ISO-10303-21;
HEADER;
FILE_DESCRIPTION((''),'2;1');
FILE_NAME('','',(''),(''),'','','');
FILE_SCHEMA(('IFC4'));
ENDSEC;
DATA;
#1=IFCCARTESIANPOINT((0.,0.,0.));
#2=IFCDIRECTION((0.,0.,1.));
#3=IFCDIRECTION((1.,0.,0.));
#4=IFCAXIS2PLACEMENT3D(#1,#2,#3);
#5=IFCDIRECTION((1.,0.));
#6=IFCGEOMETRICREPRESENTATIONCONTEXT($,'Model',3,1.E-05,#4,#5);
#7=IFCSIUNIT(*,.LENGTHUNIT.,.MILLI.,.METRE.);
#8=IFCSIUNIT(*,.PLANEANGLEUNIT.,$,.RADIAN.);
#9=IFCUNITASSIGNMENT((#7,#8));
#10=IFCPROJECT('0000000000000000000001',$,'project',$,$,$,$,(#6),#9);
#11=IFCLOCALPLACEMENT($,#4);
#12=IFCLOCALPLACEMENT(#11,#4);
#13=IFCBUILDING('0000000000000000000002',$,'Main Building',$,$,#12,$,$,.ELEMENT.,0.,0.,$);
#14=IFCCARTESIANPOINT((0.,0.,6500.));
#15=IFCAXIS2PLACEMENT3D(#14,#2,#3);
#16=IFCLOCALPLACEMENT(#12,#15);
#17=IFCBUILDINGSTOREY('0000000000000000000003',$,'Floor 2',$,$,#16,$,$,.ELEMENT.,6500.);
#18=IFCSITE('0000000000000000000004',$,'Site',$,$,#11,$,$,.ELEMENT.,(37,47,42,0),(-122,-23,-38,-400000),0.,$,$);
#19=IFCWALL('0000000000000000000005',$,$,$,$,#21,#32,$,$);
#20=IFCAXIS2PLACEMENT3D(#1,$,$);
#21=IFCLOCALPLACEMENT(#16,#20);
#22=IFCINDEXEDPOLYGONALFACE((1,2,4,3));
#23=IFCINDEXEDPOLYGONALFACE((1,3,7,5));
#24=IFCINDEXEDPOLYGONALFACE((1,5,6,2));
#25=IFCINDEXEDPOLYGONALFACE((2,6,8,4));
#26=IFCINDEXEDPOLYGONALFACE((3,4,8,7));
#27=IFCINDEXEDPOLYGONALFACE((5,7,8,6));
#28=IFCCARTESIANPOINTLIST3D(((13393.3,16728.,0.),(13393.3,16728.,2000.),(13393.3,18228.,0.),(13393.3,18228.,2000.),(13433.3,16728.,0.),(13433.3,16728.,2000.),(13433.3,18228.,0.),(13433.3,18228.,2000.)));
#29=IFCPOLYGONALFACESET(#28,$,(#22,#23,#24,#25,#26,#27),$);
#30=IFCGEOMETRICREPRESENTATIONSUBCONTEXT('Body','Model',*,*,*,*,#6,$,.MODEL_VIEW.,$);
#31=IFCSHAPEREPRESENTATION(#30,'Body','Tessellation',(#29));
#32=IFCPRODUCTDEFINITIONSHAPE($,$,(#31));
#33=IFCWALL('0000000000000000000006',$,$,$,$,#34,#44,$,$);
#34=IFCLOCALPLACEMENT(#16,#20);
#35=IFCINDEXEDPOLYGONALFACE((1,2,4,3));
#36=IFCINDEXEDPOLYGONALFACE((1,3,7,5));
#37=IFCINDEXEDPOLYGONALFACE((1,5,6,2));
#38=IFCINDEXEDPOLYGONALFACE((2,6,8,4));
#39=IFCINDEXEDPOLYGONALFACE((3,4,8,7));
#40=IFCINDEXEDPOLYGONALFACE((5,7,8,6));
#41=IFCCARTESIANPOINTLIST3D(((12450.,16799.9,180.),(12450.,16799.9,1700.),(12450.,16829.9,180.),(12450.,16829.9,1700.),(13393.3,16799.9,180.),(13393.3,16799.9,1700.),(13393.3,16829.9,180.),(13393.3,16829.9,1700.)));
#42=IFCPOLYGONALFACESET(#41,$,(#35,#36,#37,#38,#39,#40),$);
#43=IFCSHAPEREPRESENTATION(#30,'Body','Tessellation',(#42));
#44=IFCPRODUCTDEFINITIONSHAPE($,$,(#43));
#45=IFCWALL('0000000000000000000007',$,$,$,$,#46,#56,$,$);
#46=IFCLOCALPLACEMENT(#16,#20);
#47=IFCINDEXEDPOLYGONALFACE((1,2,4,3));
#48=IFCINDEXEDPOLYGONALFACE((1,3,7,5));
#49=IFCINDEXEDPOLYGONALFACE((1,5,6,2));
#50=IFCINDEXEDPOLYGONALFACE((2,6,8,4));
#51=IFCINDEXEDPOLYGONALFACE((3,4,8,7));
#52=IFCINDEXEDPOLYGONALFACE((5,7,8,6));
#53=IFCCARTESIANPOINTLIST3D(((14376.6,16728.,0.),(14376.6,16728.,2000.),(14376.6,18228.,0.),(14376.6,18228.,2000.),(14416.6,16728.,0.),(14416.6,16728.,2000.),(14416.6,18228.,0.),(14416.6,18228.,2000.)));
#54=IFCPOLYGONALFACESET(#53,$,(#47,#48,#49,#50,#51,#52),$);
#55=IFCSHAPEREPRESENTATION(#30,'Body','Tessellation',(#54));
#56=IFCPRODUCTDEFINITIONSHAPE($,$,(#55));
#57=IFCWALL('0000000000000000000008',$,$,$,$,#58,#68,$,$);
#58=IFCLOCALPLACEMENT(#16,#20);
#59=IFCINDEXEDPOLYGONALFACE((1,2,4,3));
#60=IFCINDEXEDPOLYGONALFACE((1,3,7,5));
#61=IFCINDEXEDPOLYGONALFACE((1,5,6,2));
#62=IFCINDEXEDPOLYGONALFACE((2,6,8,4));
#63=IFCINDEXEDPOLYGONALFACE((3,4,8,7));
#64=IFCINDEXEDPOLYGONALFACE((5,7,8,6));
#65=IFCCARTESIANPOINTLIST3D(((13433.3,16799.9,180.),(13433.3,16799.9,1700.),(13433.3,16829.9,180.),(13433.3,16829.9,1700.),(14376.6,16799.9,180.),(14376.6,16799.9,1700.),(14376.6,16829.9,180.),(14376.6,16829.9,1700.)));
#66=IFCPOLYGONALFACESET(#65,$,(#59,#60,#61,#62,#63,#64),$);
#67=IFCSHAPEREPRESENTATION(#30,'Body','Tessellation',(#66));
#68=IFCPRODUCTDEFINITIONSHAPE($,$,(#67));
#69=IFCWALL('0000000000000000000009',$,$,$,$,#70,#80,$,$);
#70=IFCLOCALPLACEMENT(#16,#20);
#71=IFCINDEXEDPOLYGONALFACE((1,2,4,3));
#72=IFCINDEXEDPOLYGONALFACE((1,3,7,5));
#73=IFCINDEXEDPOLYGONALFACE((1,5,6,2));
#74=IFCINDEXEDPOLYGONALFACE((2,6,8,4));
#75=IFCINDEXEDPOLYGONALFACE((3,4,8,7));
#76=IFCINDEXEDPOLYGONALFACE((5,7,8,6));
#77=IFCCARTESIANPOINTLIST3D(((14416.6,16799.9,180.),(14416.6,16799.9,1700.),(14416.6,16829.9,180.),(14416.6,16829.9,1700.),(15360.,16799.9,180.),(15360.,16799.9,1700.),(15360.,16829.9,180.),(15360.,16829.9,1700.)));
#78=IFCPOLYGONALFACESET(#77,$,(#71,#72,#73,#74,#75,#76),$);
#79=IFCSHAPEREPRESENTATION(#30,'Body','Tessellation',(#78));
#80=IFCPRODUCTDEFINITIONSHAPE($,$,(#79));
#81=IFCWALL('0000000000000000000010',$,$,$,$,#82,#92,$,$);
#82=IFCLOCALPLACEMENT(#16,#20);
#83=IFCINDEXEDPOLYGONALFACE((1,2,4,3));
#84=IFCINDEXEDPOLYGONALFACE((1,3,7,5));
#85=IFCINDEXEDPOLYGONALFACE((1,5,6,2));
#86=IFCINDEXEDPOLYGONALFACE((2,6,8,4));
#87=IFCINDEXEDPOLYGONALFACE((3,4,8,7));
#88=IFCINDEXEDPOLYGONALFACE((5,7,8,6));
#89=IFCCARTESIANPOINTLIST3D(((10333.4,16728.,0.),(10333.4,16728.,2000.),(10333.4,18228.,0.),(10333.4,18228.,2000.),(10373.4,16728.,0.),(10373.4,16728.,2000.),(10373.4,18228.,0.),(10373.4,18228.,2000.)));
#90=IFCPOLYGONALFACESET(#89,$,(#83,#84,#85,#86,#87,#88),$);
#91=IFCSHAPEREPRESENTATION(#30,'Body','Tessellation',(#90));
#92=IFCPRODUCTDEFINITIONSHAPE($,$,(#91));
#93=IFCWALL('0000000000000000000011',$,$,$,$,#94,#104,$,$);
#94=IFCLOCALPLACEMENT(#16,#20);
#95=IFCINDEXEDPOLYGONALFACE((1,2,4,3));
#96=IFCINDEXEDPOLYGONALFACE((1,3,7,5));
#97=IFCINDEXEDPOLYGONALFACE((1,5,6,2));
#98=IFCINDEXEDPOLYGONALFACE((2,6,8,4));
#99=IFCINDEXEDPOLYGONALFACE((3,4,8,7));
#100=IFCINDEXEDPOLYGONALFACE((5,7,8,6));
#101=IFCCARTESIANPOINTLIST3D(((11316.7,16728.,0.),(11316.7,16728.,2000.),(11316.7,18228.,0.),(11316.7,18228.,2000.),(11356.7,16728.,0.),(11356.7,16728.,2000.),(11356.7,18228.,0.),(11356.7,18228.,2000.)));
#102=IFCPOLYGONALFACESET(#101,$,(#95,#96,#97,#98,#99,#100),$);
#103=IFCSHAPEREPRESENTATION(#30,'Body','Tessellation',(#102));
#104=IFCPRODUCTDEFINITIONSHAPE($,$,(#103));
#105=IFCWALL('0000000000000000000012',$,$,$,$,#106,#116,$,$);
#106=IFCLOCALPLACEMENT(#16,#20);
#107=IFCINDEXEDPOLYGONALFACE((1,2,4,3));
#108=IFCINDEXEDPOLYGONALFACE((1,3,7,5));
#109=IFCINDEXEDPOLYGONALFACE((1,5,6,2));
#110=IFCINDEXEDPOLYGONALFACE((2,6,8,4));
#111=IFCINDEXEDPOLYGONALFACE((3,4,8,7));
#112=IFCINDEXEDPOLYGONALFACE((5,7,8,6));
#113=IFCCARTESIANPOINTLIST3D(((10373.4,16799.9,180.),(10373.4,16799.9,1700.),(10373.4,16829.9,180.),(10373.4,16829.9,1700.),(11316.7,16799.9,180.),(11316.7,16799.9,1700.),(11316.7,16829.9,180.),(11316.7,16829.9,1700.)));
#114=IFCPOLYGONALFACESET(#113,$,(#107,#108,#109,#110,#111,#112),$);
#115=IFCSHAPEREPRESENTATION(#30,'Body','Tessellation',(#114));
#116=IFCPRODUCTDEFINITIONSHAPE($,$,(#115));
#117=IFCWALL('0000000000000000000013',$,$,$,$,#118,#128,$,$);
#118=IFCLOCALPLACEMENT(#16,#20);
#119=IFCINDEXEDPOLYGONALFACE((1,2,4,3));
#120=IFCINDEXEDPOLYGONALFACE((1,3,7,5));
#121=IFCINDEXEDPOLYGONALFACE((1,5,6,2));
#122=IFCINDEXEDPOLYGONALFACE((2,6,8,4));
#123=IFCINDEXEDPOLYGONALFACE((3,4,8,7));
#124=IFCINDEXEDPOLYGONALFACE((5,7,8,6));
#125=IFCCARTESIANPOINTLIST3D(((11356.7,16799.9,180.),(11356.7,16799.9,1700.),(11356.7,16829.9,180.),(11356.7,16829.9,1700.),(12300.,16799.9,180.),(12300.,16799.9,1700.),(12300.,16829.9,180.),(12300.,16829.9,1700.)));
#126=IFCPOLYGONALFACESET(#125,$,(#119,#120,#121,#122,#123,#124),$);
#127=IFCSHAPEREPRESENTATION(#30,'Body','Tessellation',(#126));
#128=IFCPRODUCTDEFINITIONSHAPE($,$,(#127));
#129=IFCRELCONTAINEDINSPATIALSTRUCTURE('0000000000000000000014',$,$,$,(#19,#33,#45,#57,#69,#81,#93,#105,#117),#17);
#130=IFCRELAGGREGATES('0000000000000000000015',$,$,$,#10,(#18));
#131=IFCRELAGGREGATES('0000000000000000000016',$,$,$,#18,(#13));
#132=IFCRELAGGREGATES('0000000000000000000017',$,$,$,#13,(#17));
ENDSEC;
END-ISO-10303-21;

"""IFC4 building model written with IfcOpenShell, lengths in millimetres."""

from ifc_helpers import new_model, si_unit, direction, frame, frame_2d, origin_with_axes, origin_2d_with_axis, place, context, subcontext, project, spatial, rectangle, extrude, element, save


model = new_model("IFC4")

# Units and contexts
model_context = context("Model", 3, precision=1e-05, world=origin_with_axes(), true_north=direction((1.0, 0.0)))
body_context = subcontext(model_context, "Body", "Model", "MODEL_VIEW")
ifc_project = project(units=[si_unit("LENGTHUNIT", "METRE", prefix="MILLI"), si_unit("PLANEANGLEUNIT", "RADIAN")], contexts=[model_context])

# Site, building, storey
site_placement = place(None, origin_with_axes())
site = spatial("IfcSite", under=ifc_project, at=site_placement, Name="Site", CompositionType="ELEMENT", RefLatitude=(37, 47, 42, 0), RefLongitude=(-122, -23, -38, -400000), RefElevation=0.0)
building_placement = place(site_placement, origin_with_axes())
building = spatial("IfcBuilding", under=site, at=building_placement, Name="Main Building", CompositionType="ELEMENT", ElevationOfRefHeight=0.0, ElevationOfTerrain=0.0)
storey_placement = place(building_placement, frame((0.0, 0.0, 6500.0), z_axis=(0.0, 0.0, 1.0), x_axis=(1.0, 0.0, 0.0)))
storey = spatial("IfcBuildingStorey", under=building, at=storey_placement, Name="Floor 2", CompositionType="ELEMENT", Elevation=6500.0)

# Walls
wall_1_placement = place(storey_placement, origin_with_axes())
element("IfcWall", 1, at=wall_1_placement, inside=storey, context=body_context, shape_type="SweptSolid", body=[
    extrude(rectangle(XDim=1500.0, YDim=40.0, at=frame_2d((0.0, 0.0), x_axis=(0.0, 1.0))), frame((13413.3, 17478.0, 0.0), z_axis=(0.0, 0.0, 1.0), x_axis=(1.0, 0.0, 0.0)), (0.0, 0.0, 1.0), 2000.0),
])
wall_2_placement = place(storey_placement, origin_with_axes())
element("IfcWall", 2, at=wall_2_placement, inside=storey, context=body_context, shape_type="SweptSolid", body=[
    extrude(rectangle(XDim=943.3, YDim=30.0, at=origin_2d_with_axis()), frame((12921.7, 16814.9, 180.0), z_axis=(0.0, 0.0, 1.0), x_axis=(1.0, 0.0, 0.0)), (0.0, 0.0, 1.0), 1520.0),
])
wall_3_placement = place(storey_placement, origin_with_axes())
element("IfcWall", 3, at=wall_3_placement, inside=storey, context=body_context, shape_type="SweptSolid", body=[
    extrude(rectangle(XDim=1500.0, YDim=40.0, at=frame_2d((0.0, 0.0), x_axis=(0.0, 1.0))), frame((14396.6, 17478.0, 0.0), z_axis=(0.0, 0.0, 1.0), x_axis=(1.0, 0.0, 0.0)), (0.0, 0.0, 1.0), 2000.0),
])
wall_4_placement = place(storey_placement, origin_with_axes())
element("IfcWall", 4, at=wall_4_placement, inside=storey, context=body_context, shape_type="SweptSolid", body=[
    extrude(rectangle(XDim=943.3, YDim=30.0, at=origin_2d_with_axis()), frame((13905.0, 16814.9, 180.0), z_axis=(0.0, 0.0, 1.0), x_axis=(1.0, 0.0, 0.0)), (0.0, 0.0, 1.0), 1520.0),
])
wall_5_placement = place(storey_placement, origin_with_axes())
element("IfcWall", 5, at=wall_5_placement, inside=storey, context=body_context, shape_type="SweptSolid", body=[
    extrude(rectangle(XDim=943.3, YDim=30.0, at=origin_2d_with_axis()), frame((14888.3, 16814.9, 180.0), z_axis=(0.0, 0.0, 1.0), x_axis=(1.0, 0.0, 0.0)), (0.0, 0.0, 1.0), 1520.0),
])
wall_6_placement = place(storey_placement, origin_with_axes())
element("IfcWall", 6, at=wall_6_placement, inside=storey, context=body_context, shape_type="SweptSolid", body=[
    extrude(rectangle(XDim=1500.0, YDim=40.0, at=frame_2d((0.0, 0.0), x_axis=(0.0, 1.0))), frame((10353.4, 17478.0, 0.0), z_axis=(0.0, 0.0, 1.0), x_axis=(1.0, 0.0, 0.0)), (0.0, 0.0, 1.0), 2000.0),
])
wall_7_placement = place(storey_placement, origin_with_axes())
element("IfcWall", 7, at=wall_7_placement, inside=storey, context=body_context, shape_type="SweptSolid", body=[
    extrude(rectangle(XDim=1500.0, YDim=40.0, at=frame_2d((0.0, 0.0), x_axis=(0.0, 1.0))), frame((11336.7, 17478.0, 0.0), z_axis=(0.0, 0.0, 1.0), x_axis=(1.0, 0.0, 0.0)), (0.0, 0.0, 1.0), 2000.0),
])
wall_8_placement = place(storey_placement, origin_with_axes())
element("IfcWall", 8, at=wall_8_placement, inside=storey, context=body_context, shape_type="SweptSolid", body=[
    extrude(rectangle(XDim=943.3, YDim=30.0, at=origin_2d_with_axis()), frame((10845.0, 16814.9, 180.0), z_axis=(0.0, 0.0, 1.0), x_axis=(1.0, 0.0, 0.0)), (0.0, 0.0, 1.0), 1520.0),
])
wall_9_placement = place(storey_placement, origin_with_axes())
element("IfcWall", 9, at=wall_9_placement, inside=storey, context=body_context, shape_type="SweptSolid", body=[
    extrude(rectangle(XDim=943.3, YDim=30.0, at=origin_2d_with_axis()), frame((11828.3, 16814.9, 180.0), z_axis=(0.0, 0.0, 1.0), x_axis=(1.0, 0.0, 0.0)), (0.0, 0.0, 1.0), 1520.0),
])

save(model, "model.ifc")
